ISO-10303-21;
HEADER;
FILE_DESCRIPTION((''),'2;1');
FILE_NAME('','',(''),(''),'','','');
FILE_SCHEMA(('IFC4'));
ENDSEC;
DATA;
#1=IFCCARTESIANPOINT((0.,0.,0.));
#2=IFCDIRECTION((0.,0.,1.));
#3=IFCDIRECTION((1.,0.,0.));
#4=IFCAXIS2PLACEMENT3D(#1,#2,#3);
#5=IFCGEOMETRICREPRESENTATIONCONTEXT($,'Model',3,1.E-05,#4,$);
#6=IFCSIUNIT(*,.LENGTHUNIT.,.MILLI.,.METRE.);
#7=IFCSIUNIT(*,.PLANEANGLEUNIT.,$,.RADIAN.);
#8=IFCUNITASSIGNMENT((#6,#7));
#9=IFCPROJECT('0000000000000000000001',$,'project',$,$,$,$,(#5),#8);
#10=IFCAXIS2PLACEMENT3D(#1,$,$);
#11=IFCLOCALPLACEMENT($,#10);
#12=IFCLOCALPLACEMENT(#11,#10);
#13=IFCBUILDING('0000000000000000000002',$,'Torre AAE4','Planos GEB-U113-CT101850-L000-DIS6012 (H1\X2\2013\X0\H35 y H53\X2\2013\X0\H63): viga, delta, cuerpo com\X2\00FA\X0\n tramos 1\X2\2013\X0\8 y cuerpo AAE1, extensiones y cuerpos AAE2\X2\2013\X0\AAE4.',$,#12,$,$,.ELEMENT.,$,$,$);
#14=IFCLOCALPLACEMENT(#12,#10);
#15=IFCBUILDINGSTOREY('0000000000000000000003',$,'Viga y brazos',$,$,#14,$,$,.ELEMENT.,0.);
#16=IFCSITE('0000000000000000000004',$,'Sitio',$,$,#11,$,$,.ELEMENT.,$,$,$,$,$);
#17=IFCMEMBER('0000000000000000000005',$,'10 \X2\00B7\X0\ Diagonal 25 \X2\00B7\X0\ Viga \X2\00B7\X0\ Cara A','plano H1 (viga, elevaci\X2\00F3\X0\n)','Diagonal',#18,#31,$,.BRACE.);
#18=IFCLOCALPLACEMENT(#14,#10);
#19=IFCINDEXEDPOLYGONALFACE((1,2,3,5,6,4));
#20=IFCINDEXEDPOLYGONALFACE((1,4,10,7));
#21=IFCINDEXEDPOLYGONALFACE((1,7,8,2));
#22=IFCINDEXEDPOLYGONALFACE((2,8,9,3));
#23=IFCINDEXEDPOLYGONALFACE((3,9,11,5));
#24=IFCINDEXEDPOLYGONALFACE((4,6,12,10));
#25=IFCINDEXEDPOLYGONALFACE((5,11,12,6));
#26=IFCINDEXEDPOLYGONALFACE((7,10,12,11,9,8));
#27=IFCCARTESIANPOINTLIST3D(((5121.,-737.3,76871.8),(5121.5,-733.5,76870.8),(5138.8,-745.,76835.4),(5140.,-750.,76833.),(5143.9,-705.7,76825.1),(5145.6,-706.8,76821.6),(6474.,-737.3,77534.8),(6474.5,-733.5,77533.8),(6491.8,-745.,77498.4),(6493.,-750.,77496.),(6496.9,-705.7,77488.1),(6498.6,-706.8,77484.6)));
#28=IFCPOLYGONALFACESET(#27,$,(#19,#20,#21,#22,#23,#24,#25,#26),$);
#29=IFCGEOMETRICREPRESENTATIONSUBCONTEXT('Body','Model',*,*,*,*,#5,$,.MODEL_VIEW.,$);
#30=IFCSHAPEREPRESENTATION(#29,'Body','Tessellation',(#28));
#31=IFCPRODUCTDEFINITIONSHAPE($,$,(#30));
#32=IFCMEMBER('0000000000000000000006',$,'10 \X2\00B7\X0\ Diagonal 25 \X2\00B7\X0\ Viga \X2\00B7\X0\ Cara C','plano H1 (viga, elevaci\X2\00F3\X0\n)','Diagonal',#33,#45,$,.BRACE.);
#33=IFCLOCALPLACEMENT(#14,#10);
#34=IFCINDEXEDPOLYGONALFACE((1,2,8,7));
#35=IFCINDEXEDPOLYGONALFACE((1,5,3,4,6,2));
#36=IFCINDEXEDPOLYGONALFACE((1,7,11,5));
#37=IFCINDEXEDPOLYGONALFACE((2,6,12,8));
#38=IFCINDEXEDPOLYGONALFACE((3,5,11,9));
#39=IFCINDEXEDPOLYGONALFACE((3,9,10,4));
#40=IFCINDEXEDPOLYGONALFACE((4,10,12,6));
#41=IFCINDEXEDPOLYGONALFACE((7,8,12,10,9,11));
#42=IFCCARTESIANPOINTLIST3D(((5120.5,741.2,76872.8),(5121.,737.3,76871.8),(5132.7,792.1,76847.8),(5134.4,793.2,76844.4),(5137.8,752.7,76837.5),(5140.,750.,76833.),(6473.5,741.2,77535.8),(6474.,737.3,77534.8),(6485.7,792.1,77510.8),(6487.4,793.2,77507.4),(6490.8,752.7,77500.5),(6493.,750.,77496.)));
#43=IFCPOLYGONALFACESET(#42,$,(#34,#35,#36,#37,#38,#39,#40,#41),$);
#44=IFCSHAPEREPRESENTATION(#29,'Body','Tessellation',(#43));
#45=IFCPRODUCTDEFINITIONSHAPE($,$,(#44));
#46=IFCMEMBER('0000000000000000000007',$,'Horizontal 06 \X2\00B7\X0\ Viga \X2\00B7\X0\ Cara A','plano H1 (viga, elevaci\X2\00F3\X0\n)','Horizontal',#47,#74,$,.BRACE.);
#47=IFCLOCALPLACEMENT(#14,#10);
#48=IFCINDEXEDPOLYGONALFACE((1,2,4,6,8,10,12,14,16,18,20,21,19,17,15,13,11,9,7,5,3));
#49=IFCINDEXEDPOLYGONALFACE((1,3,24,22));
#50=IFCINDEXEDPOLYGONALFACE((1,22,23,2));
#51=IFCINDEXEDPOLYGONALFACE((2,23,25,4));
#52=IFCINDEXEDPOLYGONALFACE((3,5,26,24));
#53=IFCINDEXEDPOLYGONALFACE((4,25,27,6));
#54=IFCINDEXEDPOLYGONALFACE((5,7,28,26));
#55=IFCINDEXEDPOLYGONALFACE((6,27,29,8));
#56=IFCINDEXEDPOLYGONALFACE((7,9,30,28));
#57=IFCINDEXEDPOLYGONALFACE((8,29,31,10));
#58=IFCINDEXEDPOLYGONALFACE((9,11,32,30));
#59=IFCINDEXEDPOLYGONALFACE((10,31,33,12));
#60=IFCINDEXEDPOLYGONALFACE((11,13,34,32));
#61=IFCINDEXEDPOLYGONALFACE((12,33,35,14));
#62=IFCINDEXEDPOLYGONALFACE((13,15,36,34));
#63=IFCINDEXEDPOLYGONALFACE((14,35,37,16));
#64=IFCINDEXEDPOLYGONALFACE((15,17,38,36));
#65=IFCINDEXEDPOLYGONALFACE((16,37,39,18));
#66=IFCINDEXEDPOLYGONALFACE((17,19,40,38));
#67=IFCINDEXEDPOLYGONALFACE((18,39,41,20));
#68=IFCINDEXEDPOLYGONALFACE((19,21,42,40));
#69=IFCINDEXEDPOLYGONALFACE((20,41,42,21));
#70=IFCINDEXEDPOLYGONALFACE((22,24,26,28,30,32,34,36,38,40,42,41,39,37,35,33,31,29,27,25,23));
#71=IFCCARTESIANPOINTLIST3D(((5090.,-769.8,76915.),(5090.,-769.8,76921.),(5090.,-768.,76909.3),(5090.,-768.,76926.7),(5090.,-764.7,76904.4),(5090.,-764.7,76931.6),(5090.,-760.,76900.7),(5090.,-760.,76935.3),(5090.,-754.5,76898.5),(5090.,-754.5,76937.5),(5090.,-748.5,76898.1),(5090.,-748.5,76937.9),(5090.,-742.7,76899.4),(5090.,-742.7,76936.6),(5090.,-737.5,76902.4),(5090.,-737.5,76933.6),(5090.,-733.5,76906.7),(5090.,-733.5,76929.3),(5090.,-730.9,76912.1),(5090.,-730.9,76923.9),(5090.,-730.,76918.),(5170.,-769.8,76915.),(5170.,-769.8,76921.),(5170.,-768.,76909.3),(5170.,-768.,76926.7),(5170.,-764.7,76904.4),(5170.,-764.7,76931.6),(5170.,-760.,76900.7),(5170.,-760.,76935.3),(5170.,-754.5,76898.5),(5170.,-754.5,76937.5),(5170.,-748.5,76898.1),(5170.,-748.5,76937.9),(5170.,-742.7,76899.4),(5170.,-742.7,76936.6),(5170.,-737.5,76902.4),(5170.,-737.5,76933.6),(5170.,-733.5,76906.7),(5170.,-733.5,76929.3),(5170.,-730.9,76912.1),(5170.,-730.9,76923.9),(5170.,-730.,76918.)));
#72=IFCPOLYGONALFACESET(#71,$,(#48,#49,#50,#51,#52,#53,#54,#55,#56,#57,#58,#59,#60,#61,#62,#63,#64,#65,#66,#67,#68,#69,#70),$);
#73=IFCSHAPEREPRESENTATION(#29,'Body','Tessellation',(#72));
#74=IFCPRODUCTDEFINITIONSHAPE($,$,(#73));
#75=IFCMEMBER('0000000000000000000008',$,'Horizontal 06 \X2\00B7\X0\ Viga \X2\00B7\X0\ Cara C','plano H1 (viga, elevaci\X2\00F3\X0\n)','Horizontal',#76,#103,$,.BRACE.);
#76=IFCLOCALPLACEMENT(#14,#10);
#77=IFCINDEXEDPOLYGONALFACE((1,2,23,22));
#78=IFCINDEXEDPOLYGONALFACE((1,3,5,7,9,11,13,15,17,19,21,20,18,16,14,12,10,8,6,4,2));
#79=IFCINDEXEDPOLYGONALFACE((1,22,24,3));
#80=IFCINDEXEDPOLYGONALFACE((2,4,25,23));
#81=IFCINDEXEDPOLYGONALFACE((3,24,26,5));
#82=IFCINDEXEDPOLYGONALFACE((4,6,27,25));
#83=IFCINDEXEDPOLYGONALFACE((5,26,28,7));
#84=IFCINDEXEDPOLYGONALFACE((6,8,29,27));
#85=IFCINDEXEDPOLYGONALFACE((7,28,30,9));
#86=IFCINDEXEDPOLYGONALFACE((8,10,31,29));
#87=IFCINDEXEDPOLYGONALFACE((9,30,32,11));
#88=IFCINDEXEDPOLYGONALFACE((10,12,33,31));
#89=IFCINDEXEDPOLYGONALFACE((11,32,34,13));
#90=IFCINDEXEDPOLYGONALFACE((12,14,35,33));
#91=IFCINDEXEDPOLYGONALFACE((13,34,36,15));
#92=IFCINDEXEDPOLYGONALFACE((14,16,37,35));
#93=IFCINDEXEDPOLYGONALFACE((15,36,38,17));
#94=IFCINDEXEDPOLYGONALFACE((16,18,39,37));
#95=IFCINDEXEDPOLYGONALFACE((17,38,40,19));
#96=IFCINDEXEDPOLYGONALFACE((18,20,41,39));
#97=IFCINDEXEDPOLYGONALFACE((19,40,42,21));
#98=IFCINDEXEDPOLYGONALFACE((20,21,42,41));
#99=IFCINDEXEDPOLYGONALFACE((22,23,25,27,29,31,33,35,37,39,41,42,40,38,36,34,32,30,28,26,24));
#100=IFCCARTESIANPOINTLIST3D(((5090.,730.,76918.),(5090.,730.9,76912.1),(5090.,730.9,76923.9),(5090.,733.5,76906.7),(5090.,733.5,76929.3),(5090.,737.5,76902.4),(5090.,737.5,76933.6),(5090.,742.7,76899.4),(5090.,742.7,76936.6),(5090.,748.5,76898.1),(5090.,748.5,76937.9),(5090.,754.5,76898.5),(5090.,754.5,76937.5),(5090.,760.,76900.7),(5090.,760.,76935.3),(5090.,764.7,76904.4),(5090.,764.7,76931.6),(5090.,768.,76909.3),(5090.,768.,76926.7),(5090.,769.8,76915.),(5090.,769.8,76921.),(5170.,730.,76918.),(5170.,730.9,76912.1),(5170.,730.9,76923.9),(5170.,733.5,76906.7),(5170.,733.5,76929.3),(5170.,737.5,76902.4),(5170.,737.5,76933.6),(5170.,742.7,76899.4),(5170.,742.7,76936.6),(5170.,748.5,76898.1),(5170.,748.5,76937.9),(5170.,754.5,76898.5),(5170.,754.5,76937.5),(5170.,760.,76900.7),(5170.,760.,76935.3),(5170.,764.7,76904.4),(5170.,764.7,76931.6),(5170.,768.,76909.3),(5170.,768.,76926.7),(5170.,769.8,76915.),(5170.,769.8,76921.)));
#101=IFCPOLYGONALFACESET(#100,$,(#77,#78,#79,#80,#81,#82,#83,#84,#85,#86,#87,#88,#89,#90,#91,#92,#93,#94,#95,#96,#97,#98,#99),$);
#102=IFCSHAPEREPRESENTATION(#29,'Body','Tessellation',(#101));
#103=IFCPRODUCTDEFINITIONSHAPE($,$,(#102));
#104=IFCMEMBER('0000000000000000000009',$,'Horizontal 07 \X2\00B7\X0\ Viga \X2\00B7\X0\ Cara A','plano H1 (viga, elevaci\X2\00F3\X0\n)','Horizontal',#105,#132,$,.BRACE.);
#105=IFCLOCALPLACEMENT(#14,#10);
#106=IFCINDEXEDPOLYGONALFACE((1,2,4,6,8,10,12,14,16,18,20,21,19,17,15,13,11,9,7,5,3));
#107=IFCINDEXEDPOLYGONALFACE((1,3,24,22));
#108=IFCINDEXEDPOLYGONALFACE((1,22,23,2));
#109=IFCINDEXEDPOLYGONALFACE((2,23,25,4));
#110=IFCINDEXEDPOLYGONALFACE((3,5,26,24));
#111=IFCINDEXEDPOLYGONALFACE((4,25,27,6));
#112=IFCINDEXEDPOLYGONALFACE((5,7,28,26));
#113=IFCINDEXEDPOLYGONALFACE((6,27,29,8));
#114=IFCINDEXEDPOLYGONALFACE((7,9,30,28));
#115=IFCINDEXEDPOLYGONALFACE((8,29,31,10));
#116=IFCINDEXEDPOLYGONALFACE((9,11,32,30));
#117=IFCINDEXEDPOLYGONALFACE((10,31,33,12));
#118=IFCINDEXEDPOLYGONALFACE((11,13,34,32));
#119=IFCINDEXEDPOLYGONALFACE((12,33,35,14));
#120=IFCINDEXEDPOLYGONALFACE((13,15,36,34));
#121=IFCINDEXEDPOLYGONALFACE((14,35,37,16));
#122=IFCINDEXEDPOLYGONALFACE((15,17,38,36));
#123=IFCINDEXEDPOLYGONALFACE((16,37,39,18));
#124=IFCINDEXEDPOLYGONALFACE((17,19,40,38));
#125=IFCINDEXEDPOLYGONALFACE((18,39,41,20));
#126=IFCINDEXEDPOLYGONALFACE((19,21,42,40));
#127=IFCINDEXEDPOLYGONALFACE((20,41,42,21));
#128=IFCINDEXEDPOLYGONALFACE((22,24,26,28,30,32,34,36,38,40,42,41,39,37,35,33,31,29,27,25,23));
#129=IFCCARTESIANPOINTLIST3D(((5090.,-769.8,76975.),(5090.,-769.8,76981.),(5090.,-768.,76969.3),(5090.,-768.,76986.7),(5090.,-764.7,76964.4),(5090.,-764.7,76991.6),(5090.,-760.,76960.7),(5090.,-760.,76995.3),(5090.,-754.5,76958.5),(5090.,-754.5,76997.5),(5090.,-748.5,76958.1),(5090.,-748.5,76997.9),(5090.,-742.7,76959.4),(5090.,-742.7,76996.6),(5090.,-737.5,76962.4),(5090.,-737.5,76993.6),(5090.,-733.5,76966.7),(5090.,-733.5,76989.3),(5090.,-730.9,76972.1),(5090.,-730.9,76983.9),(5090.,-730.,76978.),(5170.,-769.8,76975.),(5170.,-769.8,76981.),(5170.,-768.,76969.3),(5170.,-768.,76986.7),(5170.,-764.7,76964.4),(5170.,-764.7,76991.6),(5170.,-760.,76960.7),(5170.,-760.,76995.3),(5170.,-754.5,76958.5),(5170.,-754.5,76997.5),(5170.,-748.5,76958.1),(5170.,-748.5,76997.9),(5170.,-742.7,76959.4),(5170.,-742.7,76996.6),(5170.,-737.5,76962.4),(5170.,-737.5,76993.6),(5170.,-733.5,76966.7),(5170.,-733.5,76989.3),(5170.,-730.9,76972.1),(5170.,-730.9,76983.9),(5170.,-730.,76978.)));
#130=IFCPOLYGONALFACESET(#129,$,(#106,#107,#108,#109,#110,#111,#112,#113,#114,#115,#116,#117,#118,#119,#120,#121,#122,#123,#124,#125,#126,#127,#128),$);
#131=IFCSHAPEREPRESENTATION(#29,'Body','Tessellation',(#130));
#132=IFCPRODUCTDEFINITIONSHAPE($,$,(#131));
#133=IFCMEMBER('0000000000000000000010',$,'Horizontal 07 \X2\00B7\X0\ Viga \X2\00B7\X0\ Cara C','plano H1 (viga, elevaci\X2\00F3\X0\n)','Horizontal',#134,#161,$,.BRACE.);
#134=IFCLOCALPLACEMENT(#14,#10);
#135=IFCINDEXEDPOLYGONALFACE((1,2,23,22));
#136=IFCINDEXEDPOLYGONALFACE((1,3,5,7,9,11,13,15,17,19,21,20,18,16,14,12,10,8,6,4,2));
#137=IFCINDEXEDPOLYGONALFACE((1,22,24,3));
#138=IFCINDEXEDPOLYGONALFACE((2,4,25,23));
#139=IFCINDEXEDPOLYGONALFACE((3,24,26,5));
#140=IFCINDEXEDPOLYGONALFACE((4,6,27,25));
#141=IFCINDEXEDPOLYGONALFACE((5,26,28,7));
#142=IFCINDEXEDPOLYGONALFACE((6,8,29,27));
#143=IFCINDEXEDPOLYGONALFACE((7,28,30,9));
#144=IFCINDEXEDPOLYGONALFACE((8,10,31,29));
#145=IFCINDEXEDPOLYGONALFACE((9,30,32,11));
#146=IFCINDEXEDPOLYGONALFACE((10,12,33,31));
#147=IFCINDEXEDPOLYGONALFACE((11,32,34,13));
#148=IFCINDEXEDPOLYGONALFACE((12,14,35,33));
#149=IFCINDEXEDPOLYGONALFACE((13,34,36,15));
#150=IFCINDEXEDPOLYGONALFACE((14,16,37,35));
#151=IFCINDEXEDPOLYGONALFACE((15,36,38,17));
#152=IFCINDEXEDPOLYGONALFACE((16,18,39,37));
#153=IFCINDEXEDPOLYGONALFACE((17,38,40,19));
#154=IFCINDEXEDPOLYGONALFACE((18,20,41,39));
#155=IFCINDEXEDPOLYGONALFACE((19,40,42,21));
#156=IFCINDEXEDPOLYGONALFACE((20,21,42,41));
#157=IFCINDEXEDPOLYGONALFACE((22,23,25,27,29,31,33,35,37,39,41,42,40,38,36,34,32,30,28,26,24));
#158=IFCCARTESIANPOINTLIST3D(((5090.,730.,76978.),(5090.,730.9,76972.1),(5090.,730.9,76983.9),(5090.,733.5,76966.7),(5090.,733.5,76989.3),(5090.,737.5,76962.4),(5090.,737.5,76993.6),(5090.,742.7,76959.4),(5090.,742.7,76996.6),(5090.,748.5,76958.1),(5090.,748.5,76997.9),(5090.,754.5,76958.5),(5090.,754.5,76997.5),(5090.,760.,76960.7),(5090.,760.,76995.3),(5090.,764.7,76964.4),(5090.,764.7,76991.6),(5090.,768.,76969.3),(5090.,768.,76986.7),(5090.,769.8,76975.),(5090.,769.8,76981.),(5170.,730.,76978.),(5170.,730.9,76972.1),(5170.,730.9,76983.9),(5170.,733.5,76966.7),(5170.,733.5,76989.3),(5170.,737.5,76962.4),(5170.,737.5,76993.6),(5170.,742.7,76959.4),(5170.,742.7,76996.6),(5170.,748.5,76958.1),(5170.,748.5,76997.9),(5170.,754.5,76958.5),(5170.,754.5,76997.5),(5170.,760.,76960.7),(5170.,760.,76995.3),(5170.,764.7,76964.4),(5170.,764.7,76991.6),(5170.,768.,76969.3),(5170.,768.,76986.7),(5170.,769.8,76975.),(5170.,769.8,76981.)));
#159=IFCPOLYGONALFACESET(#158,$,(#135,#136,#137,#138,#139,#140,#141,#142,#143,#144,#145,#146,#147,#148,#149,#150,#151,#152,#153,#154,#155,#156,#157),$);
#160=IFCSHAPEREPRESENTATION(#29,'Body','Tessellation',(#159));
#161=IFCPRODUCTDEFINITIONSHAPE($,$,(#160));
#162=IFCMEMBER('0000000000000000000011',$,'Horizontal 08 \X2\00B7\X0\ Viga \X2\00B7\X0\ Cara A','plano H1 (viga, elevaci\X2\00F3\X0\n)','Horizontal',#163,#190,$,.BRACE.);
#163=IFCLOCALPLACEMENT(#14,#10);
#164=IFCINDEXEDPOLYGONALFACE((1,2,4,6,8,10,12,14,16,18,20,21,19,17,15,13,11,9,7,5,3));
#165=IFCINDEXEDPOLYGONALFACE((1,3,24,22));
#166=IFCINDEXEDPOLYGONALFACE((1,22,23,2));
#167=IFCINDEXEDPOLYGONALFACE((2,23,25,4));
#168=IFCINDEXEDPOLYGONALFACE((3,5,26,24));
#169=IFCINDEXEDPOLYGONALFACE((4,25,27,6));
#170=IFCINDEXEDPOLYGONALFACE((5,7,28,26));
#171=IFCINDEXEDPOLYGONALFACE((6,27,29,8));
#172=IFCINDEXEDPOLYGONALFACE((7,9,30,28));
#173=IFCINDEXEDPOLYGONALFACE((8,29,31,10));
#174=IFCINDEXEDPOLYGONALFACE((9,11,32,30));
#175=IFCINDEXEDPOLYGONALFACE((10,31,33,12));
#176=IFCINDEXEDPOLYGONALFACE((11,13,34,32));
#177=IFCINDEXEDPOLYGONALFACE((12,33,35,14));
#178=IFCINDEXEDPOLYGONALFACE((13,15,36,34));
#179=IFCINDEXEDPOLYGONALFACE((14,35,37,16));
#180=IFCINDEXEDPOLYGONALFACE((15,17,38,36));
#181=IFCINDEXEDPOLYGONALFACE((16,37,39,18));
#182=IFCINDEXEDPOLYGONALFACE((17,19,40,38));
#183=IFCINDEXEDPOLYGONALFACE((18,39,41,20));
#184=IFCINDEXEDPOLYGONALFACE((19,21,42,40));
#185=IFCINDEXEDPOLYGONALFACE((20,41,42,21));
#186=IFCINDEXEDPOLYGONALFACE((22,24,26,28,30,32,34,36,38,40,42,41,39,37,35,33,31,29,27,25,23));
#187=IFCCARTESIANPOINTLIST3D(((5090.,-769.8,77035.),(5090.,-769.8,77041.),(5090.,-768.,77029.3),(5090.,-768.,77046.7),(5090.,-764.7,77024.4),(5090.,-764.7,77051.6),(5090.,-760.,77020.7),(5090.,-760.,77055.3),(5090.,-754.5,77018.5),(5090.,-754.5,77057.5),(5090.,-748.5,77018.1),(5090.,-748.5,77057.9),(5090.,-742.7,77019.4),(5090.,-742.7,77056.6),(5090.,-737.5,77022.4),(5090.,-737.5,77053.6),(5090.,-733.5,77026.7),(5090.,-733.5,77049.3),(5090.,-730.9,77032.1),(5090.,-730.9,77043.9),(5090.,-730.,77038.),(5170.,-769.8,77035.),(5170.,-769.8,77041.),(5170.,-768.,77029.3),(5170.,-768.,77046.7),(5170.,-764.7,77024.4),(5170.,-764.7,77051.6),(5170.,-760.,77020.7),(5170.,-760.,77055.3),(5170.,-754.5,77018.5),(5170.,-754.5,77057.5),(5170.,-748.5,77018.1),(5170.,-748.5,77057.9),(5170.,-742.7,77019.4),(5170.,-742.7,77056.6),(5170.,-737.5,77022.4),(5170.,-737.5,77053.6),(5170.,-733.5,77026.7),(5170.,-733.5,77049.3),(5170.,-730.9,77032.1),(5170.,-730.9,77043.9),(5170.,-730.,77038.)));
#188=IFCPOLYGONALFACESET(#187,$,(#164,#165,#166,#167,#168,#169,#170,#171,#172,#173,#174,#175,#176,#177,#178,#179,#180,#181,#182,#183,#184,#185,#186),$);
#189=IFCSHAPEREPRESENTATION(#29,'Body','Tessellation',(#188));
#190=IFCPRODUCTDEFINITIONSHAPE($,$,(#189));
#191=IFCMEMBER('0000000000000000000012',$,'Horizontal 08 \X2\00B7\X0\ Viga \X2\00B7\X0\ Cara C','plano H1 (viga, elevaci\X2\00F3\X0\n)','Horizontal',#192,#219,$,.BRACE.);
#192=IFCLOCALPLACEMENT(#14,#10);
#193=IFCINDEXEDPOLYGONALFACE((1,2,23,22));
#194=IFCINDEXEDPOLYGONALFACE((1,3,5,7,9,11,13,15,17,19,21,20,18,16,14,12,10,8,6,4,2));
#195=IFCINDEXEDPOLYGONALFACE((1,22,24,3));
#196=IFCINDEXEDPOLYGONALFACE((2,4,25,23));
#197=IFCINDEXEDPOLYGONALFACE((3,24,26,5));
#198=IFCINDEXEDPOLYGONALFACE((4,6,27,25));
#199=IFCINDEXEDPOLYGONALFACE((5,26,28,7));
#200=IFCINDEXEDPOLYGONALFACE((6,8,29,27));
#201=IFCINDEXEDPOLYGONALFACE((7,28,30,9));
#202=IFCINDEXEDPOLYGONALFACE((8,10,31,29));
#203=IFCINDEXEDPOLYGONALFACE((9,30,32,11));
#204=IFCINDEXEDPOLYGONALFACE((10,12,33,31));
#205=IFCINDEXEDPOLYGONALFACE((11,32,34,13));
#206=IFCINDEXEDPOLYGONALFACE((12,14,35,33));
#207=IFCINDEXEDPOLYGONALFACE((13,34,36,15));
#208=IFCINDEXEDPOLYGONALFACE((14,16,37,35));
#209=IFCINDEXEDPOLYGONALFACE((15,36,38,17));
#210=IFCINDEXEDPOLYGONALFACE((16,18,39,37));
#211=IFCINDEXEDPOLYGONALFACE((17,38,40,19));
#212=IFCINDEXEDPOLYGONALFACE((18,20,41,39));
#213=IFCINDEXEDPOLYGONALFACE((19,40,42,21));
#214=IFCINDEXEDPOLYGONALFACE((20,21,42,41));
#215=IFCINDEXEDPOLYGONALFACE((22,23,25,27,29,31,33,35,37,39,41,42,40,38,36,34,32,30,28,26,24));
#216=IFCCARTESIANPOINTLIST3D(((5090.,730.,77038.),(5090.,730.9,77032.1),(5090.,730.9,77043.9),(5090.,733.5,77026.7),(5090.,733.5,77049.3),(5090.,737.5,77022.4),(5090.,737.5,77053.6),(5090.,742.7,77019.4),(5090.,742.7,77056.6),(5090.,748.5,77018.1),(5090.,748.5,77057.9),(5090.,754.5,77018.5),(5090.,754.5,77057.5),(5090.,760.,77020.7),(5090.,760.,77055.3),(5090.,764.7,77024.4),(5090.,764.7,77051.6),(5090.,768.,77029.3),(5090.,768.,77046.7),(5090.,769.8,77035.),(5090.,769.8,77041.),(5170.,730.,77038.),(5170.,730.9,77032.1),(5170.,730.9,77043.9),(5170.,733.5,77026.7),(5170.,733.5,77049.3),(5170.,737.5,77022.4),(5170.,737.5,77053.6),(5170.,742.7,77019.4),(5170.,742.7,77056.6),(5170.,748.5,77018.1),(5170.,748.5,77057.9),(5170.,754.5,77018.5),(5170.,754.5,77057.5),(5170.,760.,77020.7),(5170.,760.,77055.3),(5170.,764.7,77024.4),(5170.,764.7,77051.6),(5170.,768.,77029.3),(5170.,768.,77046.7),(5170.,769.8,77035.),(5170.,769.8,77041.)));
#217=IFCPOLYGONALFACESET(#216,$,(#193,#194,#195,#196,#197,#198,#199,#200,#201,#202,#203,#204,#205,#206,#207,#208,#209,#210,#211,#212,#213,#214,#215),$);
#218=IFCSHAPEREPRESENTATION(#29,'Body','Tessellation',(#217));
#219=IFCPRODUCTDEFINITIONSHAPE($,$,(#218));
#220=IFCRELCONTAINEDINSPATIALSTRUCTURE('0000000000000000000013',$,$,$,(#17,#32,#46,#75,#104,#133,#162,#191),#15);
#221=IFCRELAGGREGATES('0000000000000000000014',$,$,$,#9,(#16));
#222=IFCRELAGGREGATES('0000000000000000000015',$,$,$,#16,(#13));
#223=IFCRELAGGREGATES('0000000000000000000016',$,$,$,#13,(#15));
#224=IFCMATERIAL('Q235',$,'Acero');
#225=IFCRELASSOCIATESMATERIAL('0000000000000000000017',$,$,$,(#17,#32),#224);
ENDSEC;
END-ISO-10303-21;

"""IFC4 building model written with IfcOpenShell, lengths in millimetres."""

from ifc_helpers import new_model, si_unit, frame, frame_2d, origin, origin_with_axes, place, context, subcontext, project, spatial, circle, l_section, extrude, material, element, save


model = new_model("IFC4")

# Units and contexts
model_context = context("Model", 3, precision=1e-05, world=origin_with_axes())
body_context = subcontext(model_context, "Body", "Model", "MODEL_VIEW")
ifc_project = project(units=[si_unit("LENGTHUNIT", "METRE", prefix="MILLI"), si_unit("PLANEANGLEUNIT", "RADIAN")], contexts=[model_context])

# Site, building, storey
site_placement = place(None, origin())
site = spatial("IfcSite", under=ifc_project, at=site_placement, Name="Sitio", CompositionType="ELEMENT")
building_placement = place(site_placement, origin())
building = spatial("IfcBuilding", under=site, at=building_placement, Name="Torre AAE4", Description="Planos GEB-U113-CT101850-L000-DIS6012 (H1–H35 y H53–H63): viga, delta, cuerpo común tramos 1–8 y cuerpo AAE1, extensiones y cuerpos AAE2–AAE4.", CompositionType="ELEMENT")
storey_placement = place(building_placement, origin())
storey = spatial("IfcBuildingStorey", under=building, at=storey_placement, Name="Viga y brazos", CompositionType="ELEMENT", Elevation=0.0)

# Members
ifc_material = material(Name="Q235", Category="Acero")
for number, where, z_axis, x_axis, name in (
    (1, (6493.0, -750.0, 77496.0), (-0.897982, 0.0, -0.440031), (-0.422275, 0.281208, 0.861746), "10 · Diagonal 25 · Viga · Cara A"),
    (2, (6493.0, 750.0, 77496.0), (-0.897982, 0.0, -0.440031), (-0.422275, -0.281208, 0.861746), "10 · Diagonal 25 · Viga · Cara C"),
):
    element("IfcMember", number, at=place(storey_placement, frame(where, z_axis=z_axis, x_axis=x_axis)), inside=storey, material=ifc_material, Name=name, Description="plano H1 (viga, elevación)", ObjectType="Diagonal", PredefinedType="BRACE", context=body_context, shape_type="SweptSolid", body=[
        extrude(l_section(Depth=45.0, Width=45.0, Thickness=4.0, at=frame_2d((22.5, 22.5))), None, (0.0, 0.0, 1.0), 1506.7),
    ])
for number, where, z_axis, x_axis, name in (
    (3, (5170.0, -750.0, 76918.0), (-1.0, 0.0, 0.0), (0.0, 1.0, 0.0), "Horizontal 06 · Viga · Cara A"),
    (4, (5170.0, 750.0, 76918.0), (-1.0, 0.0, 0.0), (0.0, -1.0, 0.0), "Horizontal 06 · Viga · Cara C"),
    (5, (5170.0, -750.0, 76978.0), (-1.0, 0.0, 0.0), (0.0, 1.0, 0.0), "Horizontal 07 · Viga · Cara A"),
    (6, (5170.0, 750.0, 76978.0), (-1.0, 0.0, 0.0), (0.0, -1.0, 0.0), "Horizontal 07 · Viga · Cara C"),
    (7, (5170.0, -750.0, 77038.0), (-1.0, 0.0, 0.0), (0.0, 1.0, 0.0), "Horizontal 08 · Viga · Cara A"),
    (8, (5170.0, 750.0, 77038.0), (-1.0, 0.0, 0.0), (0.0, -1.0, 0.0), "Horizontal 08 · Viga · Cara C"),
):
    element("IfcMember", number, at=place(storey_placement, frame(where, z_axis=z_axis, x_axis=x_axis)), inside=storey, Name=name, Description="plano H1 (viga, elevación)", ObjectType="Horizontal", PredefinedType="BRACE", context=body_context, shape_type="SweptSolid", body=[
        extrude(circle(Radius=20.0), None, (0.0, 0.0, 1.0), 80.0),
    ])

save(model, "model.ifc")
